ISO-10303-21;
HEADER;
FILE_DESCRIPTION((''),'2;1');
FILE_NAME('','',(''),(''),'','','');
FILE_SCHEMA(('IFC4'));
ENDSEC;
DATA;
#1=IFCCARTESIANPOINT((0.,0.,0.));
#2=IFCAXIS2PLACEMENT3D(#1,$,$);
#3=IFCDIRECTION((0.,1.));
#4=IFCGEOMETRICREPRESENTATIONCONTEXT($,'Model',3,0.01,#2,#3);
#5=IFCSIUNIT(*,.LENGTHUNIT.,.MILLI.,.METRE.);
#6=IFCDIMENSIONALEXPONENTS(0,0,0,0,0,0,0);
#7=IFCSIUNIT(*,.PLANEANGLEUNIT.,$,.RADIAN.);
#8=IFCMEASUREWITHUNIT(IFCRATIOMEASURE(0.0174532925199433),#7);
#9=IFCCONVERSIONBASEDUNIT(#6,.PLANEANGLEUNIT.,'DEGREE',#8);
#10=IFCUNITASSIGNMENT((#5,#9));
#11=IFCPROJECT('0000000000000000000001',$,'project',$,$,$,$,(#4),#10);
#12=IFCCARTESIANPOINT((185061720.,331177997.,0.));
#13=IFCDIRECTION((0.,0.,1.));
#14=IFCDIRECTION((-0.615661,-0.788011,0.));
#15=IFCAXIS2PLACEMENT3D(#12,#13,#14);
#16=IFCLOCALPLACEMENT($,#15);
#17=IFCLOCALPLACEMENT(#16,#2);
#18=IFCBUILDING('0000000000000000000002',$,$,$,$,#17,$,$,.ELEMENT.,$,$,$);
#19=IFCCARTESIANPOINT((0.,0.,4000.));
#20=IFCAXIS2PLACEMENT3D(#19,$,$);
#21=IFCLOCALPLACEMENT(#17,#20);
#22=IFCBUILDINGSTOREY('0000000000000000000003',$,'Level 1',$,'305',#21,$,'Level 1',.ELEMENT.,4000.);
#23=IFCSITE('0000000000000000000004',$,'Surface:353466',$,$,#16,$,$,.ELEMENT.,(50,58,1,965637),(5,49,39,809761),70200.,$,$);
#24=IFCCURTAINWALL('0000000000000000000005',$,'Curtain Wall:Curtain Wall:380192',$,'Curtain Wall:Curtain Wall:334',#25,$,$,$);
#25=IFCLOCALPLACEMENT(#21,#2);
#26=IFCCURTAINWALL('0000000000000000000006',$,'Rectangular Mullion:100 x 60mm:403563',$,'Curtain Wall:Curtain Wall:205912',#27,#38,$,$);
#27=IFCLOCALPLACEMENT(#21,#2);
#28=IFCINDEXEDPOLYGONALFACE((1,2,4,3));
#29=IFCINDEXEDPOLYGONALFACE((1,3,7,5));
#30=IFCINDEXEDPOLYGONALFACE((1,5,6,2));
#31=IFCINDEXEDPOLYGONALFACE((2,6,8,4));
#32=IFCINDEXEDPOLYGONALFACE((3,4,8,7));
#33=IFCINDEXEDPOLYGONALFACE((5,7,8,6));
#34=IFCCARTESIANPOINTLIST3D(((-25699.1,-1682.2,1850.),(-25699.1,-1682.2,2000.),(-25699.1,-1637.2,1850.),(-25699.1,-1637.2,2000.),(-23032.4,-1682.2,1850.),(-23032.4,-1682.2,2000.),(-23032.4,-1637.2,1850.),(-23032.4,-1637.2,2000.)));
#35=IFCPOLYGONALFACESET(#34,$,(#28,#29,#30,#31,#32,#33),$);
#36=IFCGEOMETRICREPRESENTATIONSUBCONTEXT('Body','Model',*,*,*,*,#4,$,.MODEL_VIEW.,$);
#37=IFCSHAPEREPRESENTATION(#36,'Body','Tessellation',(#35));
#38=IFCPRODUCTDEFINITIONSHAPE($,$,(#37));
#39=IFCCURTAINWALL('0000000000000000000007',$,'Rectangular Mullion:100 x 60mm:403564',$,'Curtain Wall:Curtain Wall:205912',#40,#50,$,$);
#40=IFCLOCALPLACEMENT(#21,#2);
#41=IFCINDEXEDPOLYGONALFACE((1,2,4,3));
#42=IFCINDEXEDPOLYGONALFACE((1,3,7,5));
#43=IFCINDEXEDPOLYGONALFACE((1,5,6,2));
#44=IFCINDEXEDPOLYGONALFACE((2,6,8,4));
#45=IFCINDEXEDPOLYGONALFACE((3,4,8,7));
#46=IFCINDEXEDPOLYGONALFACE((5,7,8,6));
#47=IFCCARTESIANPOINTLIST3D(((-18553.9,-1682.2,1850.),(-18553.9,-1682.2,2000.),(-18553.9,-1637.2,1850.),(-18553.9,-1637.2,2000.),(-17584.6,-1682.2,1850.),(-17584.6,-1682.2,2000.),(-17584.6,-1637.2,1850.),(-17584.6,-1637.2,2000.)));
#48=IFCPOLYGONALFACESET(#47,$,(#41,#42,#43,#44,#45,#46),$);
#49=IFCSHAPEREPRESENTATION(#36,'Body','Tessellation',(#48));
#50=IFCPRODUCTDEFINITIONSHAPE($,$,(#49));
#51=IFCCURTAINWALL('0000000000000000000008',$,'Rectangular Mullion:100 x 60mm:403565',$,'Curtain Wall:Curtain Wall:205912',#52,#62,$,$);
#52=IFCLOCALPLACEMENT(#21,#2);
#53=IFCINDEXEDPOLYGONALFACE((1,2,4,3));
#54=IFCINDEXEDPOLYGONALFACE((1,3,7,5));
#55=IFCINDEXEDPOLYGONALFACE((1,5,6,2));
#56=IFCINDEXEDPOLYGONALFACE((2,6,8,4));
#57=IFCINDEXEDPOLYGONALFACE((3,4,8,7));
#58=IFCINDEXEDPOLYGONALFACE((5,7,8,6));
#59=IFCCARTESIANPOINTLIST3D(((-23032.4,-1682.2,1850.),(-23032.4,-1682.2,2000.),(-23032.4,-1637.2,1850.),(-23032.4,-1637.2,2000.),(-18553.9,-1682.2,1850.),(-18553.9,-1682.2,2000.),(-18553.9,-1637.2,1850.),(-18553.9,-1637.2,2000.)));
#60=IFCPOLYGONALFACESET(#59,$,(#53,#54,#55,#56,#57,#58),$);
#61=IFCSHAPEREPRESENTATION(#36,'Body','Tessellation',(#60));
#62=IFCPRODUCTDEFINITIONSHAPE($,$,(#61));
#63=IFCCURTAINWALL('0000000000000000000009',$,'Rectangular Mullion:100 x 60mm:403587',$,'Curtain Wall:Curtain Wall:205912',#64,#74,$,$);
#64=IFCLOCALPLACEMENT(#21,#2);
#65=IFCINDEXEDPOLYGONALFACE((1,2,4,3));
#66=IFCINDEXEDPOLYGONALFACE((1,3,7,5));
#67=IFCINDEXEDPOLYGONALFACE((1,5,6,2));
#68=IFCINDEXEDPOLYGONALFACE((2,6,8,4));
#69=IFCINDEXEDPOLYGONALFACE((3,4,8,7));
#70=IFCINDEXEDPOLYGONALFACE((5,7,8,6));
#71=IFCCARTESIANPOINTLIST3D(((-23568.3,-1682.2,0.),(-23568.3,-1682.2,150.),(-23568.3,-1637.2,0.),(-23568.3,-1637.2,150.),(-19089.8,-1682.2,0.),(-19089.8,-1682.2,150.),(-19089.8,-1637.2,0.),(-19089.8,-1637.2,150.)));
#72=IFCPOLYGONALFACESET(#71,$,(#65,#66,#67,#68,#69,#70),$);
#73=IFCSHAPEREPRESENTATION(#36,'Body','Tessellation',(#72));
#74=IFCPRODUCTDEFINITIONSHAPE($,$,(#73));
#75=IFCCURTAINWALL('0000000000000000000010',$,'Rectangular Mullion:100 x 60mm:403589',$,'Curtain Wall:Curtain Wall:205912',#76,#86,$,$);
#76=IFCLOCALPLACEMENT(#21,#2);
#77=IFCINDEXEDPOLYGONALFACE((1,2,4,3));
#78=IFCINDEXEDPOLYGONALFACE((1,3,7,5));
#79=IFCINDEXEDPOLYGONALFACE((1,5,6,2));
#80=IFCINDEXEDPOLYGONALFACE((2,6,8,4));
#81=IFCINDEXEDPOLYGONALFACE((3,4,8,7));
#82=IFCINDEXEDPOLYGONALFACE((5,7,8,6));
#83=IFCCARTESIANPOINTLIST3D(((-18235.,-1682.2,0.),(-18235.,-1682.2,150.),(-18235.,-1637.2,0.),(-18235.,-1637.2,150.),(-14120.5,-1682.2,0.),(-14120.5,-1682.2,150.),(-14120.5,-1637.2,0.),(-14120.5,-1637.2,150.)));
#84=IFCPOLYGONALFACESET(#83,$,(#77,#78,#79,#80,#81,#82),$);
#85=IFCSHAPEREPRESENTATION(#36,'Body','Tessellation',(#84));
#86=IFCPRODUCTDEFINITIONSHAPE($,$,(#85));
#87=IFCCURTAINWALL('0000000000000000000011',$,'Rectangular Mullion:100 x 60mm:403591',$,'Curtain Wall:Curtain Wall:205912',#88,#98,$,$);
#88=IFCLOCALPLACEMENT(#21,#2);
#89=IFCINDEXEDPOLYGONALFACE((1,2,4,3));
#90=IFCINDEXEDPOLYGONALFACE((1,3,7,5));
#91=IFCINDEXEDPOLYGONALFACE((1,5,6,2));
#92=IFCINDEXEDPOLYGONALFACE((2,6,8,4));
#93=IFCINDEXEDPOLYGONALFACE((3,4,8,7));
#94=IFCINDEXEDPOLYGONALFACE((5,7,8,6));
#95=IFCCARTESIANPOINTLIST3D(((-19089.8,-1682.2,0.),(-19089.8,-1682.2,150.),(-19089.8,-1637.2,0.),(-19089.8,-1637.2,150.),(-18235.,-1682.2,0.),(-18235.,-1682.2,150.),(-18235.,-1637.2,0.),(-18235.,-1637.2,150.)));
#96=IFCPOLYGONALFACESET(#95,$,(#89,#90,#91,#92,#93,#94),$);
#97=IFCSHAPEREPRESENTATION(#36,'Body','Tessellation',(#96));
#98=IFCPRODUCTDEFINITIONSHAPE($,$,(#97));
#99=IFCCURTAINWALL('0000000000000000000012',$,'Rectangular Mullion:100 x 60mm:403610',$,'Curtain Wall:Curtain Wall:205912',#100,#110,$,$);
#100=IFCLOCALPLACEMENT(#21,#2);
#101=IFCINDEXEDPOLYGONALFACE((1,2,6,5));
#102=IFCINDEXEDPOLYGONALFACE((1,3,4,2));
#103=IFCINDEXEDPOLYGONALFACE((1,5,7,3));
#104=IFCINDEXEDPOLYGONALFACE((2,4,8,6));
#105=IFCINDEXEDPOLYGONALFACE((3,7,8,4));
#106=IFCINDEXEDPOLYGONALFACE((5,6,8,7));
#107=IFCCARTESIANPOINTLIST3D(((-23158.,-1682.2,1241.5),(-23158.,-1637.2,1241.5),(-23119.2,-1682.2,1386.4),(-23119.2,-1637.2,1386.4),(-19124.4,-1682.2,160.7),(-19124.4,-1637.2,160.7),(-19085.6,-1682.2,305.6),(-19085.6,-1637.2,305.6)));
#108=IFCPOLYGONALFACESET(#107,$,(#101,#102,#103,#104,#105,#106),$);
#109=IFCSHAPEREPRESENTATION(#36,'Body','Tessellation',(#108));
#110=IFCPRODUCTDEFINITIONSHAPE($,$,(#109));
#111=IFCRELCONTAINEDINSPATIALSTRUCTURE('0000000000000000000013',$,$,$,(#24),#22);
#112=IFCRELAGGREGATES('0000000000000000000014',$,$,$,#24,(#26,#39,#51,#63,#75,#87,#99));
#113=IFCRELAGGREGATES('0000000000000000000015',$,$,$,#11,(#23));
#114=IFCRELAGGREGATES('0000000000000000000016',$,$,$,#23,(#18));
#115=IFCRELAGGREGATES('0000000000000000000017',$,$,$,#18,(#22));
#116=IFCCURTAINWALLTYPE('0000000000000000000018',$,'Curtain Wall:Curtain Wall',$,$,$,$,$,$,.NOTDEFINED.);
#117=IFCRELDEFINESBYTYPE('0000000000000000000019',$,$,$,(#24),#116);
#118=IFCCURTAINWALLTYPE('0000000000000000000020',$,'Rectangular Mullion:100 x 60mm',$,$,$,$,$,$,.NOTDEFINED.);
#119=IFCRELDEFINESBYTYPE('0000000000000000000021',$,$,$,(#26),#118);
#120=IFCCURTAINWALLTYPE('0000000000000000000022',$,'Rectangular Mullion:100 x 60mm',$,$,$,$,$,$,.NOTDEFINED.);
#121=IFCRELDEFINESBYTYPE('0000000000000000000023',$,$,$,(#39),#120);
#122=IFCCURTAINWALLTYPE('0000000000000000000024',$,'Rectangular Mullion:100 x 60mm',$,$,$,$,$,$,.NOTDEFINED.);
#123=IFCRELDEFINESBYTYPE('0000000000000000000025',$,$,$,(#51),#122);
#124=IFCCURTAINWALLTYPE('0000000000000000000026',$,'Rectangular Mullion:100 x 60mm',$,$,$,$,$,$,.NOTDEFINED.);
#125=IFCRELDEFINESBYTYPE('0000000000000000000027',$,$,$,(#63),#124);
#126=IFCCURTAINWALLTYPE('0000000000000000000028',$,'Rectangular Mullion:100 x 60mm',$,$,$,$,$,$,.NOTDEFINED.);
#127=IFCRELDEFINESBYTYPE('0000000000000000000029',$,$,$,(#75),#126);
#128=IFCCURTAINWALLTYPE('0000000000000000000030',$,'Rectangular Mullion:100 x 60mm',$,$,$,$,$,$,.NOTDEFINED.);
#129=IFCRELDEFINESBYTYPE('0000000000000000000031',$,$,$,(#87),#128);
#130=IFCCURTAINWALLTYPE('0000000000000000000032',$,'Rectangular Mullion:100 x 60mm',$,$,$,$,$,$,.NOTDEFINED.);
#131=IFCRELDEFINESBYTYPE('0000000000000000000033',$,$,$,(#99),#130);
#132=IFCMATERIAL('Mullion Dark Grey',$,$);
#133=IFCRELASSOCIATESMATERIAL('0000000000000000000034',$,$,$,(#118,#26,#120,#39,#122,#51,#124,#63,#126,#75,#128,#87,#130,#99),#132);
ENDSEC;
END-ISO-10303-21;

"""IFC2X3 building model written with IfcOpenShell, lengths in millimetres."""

from ifc_helpers import new_model, entity, si_unit, converted_unit, direction, frame, frame_2d, origin, place, context, subcontext, project, spatial, rectangle, extrude, source, transform, mapped, material, type_object, type_shapes, element, aggregate, save


model = new_model("IFC2X3")

# Units and contexts
model_context = context("Model", 3, precision=0.01, world=origin(), true_north=direction((0.0, 1.0)))
body_context = subcontext(model_context, "Body", "Model", "MODEL_VIEW")
ifc_project = project(units=[si_unit("LENGTHUNIT", "METRE", prefix="MILLI"), converted_unit("PLANEANGLEUNIT", "DEGREE", entity("IfcRatioMeasure", 0.0174532925199433), si_unit("PLANEANGLEUNIT", "RADIAN"), dimensions=[0, 0, 0, 0, 0, 0, 0])], contexts=[model_context])

# Site, building, storey
site_placement = place(None, frame((185061720.0, 331177997.0, 0.0), z_axis=(0.0, 0.0, 1.0), x_axis=(-0.615661, -0.788011, 0.0)))
site = spatial("IfcSite", under=ifc_project, at=site_placement, Name="Surface:353466", CompositionType="ELEMENT", RefLatitude=(50, 58, 1, 965637), RefLongitude=(5, 49, 39, 809761), RefElevation=70200.0)
building_placement = place(site_placement, origin())
building = spatial("IfcBuilding", under=site, at=building_placement, CompositionType="ELEMENT")
storey_placement = place(building_placement, frame((0.0, 0.0, 4000.0)))
storey = spatial("IfcBuildingStorey", under=building, at=storey_placement, Name="Level 1", ObjectType="305", LongName="Level 1", CompositionType="ELEMENT", Elevation=4000.0)

# Curtain walls
curtain_wall_type_1 = type_object("IfcCurtainWallType", Name="Curtain Wall:Curtain Wall", PredefinedType="NOTDEFINED")
curtain_wall_1_placement = place(storey_placement, frame((0.0, 0.0, -4000.0)))
curtain_wall_1 = element("IfcCurtainWall", 1, at=curtain_wall_1_placement, inside=storey, type_object=curtain_wall_type_1, Name="Curtain Wall:Curtain Wall:380192", ObjectType="Curtain Wall:Curtain Wall:334")
ifc_material_1 = material(Name="Mullion Dark Grey")
curtain_wall_type_2 = type_object("IfcCurtainWallType", Name="Rectangular Mullion:100 x 60mm", PredefinedType="NOTDEFINED", material=ifc_material_1)
shared_shape_1 = source(origin(), body_context, "Body", "SweptSolid", [
    extrude(rectangle(XDim=45.0, YDim=150.0, at=frame_2d((0.0, 0.0), x_axis=(1.0, 0.0))), frame((-75.0, 7.5, -2666.7), z_axis=(0.0, 0.0, 1.0), x_axis=(0.0, -1.0, 0.0)), (0.0, 0.0, 1.0), 2666.7),
])
type_shapes(curtain_wall_type_2, [shared_shape_1])
curtain_wall_2_placement = place(storey_placement, frame((-23032.4, -1652.2, 2000.0), z_axis=(1.0, 0.0, 0.0), x_axis=(0.0, 0.0, 1.0)))
curtain_wall_2 = element("IfcCurtainWall", 2, at=curtain_wall_2_placement, type_object=curtain_wall_type_2, material=ifc_material_1, Name="Rectangular Mullion:100 x 60mm:403563", ObjectType="Curtain Wall:Curtain Wall:205912", context=body_context, shape_type="MappedRepresentation", body=[
    mapped(shared_shape_1, transform((0.0, 0.0, 0.0), scale=1.0)),
])
curtain_wall_type_3 = type_object("IfcCurtainWallType", Name="Rectangular Mullion:100 x 60mm", PredefinedType="NOTDEFINED", material=ifc_material_1)
shared_shape_2 = source(origin(), body_context, "Body", "SweptSolid", [
    extrude(rectangle(XDim=45.0, YDim=150.0, at=frame_2d((0.0, 0.0), x_axis=(1.0, 0.0))), frame((-75.0, 7.5, -969.3), z_axis=(0.0, 0.0, 1.0), x_axis=(0.0, -1.0, 0.0)), (0.0, 0.0, 1.0), 969.3),
])
type_shapes(curtain_wall_type_3, [shared_shape_2])
curtain_wall_3_placement = place(storey_placement, frame((-17584.6, -1652.2, 2000.0), z_axis=(1.0, 0.0, 0.0), x_axis=(0.0, 0.0, 1.0)))
curtain_wall_3 = element("IfcCurtainWall", 3, at=curtain_wall_3_placement, type_object=curtain_wall_type_3, material=ifc_material_1, Name="Rectangular Mullion:100 x 60mm:403564", ObjectType="Curtain Wall:Curtain Wall:205912", context=body_context, shape_type="MappedRepresentation", body=[
    mapped(shared_shape_2, transform((0.0, 0.0, 0.0), scale=1.0)),
])
curtain_wall_type_4 = type_object("IfcCurtainWallType", Name="Rectangular Mullion:100 x 60mm", PredefinedType="NOTDEFINED", material=ifc_material_1)
shared_shape_3 = source(origin(), body_context, "Body", "SweptSolid", [
    extrude(rectangle(XDim=45.0, YDim=150.0, at=frame_2d((0.0, 0.0), x_axis=(1.0, 0.0))), frame((-75.0, 7.5, -4478.5), z_axis=(0.0, 0.0, 1.0), x_axis=(0.0, -1.0, 0.0)), (0.0, 0.0, 1.0), 4478.5),
])
type_shapes(curtain_wall_type_4, [shared_shape_3])
curtain_wall_4_placement = place(storey_placement, frame((-18553.9, -1652.2, 2000.0), z_axis=(1.0, 0.0, 0.0), x_axis=(0.0, 0.0, 1.0)))
curtain_wall_4 = element("IfcCurtainWall", 4, at=curtain_wall_4_placement, type_object=curtain_wall_type_4, material=ifc_material_1, Name="Rectangular Mullion:100 x 60mm:403565", ObjectType="Curtain Wall:Curtain Wall:205912", context=body_context, shape_type="MappedRepresentation", body=[
    mapped(shared_shape_3, transform((0.0, 0.0, 0.0), scale=1.0)),
])
curtain_wall_type_5 = type_object("IfcCurtainWallType", Name="Rectangular Mullion:100 x 60mm", PredefinedType="NOTDEFINED", material=ifc_material_1)
shared_shape_4 = source(origin(), body_context, "Body", "SweptSolid", [
    extrude(rectangle(XDim=150.0, YDim=45.0, at=frame_2d((0.0, 0.0), x_axis=(1.0, 0.0))), frame((-75.0, 7.5, -4478.5), z_axis=(0.0, 0.0, 1.0), x_axis=(-1.0, 0.0, 0.0)), (0.0, 0.0, 1.0), 4478.5),
])
type_shapes(curtain_wall_type_5, [shared_shape_4])
curtain_wall_5_placement = place(storey_placement, frame((-23568.3, -1652.2, 0.0), z_axis=(-1.0, 0.0, 0.0), x_axis=(0.0, 0.0, -1.0)))
curtain_wall_5 = element("IfcCurtainWall", 5, at=curtain_wall_5_placement, type_object=curtain_wall_type_5, material=ifc_material_1, Name="Rectangular Mullion:100 x 60mm:403587", ObjectType="Curtain Wall:Curtain Wall:205912", context=body_context, shape_type="MappedRepresentation", body=[
    mapped(shared_shape_4, transform((0.0, 0.0, 0.0), scale=1.0)),
])
curtain_wall_type_6 = type_object("IfcCurtainWallType", Name="Rectangular Mullion:100 x 60mm", PredefinedType="NOTDEFINED", material=ifc_material_1)
shared_shape_5 = source(origin(), body_context, "Body", "SweptSolid", [
    extrude(rectangle(XDim=150.0, YDim=45.0, at=frame_2d((0.0, 0.0), x_axis=(1.0, 0.0))), frame((-75.0, 7.5, -4114.5), z_axis=(0.0, 0.0, 1.0), x_axis=(-1.0, 0.0, 0.0)), (0.0, 0.0, 1.0), 4114.5),
])
type_shapes(curtain_wall_type_6, [shared_shape_5])
curtain_wall_6_placement = place(storey_placement, frame((-18235.0, -1652.2, 0.0), z_axis=(-1.0, 0.0, 0.0), x_axis=(0.0, 0.0, -1.0)))
curtain_wall_6 = element("IfcCurtainWall", 6, at=curtain_wall_6_placement, type_object=curtain_wall_type_6, material=ifc_material_1, Name="Rectangular Mullion:100 x 60mm:403589", ObjectType="Curtain Wall:Curtain Wall:205912", context=body_context, shape_type="MappedRepresentation", body=[
    mapped(shared_shape_5, transform((0.0, 0.0, 0.0), scale=1.0)),
])
curtain_wall_type_7 = type_object("IfcCurtainWallType", Name="Rectangular Mullion:100 x 60mm", PredefinedType="NOTDEFINED", material=ifc_material_1)
shared_shape_6 = source(origin(), body_context, "Body", "SweptSolid", [
    extrude(rectangle(XDim=150.0, YDim=45.0, at=frame_2d((0.0, 0.0), x_axis=(1.0, 0.0))), frame((-75.0, 7.5, -854.8), z_axis=(0.0, 0.0, 1.0), x_axis=(-1.0, 0.0, 0.0)), (0.0, 0.0, 1.0), 854.8),
])
type_shapes(curtain_wall_type_7, [shared_shape_6])
curtain_wall_7_placement = place(storey_placement, frame((-19089.8, -1652.2, 0.0), z_axis=(-1.0, 0.0, 0.0), x_axis=(0.0, 0.0, -1.0)))
curtain_wall_7 = element("IfcCurtainWall", 7, at=curtain_wall_7_placement, type_object=curtain_wall_type_7, material=ifc_material_1, Name="Rectangular Mullion:100 x 60mm:403591", ObjectType="Curtain Wall:Curtain Wall:205912", context=body_context, shape_type="MappedRepresentation", body=[
    mapped(shared_shape_6, transform((0.0, 0.0, 0.0), scale=1.0)),
])
curtain_wall_type_8 = type_object("IfcCurtainWallType", Name="Rectangular Mullion:100 x 60mm", PredefinedType="NOTDEFINED", material=ifc_material_1)
shared_shape_7 = source(origin(), body_context, "Body", "SweptSolid", [
    extrude(rectangle(XDim=45.0, YDim=150.0, at=frame_2d((0.0, 0.0), x_axis=(1.0, 0.0))), frame((0.0, 7.5, -4175.9), z_axis=(0.0, 0.0, 1.0), x_axis=(0.0, -1.0, 0.0)), (0.0, 0.0, 1.0), 4175.9),
])
type_shapes(curtain_wall_type_8, [shared_shape_7])
curtain_wall_8_placement = place(storey_placement, frame((-19105.0, -1652.2, 233.1), z_axis=(0.965926, 0.0, -0.258819), x_axis=(0.258819, 0.0, 0.965926)))
curtain_wall_8 = element("IfcCurtainWall", 8, at=curtain_wall_8_placement, type_object=curtain_wall_type_8, material=ifc_material_1, Name="Rectangular Mullion:100 x 60mm:403610", ObjectType="Curtain Wall:Curtain Wall:205912", context=body_context, shape_type="MappedRepresentation", body=[
    mapped(shared_shape_7, transform((0.0, 0.0, 0.0), scale=1.0)),
])
aggregate(curtain_wall_1, [curtain_wall_2, curtain_wall_3, curtain_wall_4, curtain_wall_5, curtain_wall_6, curtain_wall_7, curtain_wall_8])

save(model, "model.ifc")
